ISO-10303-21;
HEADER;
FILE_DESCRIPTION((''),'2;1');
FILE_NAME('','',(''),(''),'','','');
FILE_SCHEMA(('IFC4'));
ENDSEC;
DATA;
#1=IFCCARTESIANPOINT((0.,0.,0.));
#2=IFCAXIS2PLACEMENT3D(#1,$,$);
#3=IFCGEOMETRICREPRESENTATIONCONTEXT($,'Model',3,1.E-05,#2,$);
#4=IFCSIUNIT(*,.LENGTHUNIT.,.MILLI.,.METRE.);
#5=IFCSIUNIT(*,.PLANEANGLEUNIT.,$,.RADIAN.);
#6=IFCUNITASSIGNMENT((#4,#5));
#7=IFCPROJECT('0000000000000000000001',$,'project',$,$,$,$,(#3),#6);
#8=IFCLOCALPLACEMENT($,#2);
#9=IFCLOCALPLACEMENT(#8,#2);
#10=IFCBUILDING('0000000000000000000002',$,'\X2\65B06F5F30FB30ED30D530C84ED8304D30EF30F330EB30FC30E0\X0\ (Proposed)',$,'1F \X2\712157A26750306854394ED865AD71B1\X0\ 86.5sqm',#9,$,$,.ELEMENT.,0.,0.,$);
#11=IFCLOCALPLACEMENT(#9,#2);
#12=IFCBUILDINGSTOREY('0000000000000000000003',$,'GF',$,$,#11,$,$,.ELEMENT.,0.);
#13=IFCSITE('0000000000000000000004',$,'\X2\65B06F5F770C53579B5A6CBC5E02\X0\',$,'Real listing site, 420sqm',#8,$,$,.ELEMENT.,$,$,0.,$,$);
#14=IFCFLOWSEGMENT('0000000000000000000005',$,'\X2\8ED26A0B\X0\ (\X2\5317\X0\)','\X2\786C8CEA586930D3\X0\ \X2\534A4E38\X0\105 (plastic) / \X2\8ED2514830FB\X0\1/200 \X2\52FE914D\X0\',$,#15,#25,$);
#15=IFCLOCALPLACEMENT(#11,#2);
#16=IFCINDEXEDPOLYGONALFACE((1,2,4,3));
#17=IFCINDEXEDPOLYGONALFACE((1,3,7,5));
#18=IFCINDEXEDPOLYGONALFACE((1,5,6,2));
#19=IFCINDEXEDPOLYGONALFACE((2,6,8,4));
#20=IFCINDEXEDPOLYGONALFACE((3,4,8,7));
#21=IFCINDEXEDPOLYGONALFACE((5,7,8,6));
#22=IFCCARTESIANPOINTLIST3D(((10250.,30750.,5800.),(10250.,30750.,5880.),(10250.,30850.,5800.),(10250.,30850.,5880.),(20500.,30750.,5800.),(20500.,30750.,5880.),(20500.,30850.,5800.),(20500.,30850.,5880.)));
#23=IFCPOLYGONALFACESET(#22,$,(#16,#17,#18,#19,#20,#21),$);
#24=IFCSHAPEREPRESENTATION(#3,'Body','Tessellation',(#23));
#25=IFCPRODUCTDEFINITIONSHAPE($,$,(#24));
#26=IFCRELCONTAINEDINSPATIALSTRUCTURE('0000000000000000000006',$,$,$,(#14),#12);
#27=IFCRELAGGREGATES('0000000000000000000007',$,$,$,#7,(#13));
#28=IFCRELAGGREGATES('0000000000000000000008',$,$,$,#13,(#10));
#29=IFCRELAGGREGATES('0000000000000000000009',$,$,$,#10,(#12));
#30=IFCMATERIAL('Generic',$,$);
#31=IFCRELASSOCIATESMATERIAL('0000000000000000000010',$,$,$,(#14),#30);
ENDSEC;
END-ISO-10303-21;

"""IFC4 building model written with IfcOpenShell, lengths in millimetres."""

from ifc_helpers import new_model, si_unit, frame, frame_2d, origin, place, context, project, spatial, rectangle, extrude, material, element, save


model = new_model("IFC4")

# Units and contexts
model_context = context("Model", 3, precision=1e-05, world=origin())
ifc_project = project(units=[si_unit("LENGTHUNIT", "METRE", prefix="MILLI"), si_unit("PLANEANGLEUNIT", "RADIAN")], contexts=[model_context])

# Site, building, storey
site_placement = place(None, origin())
site = spatial("IfcSite", under=ifc_project, at=site_placement, Name="新潟県南魚沼市", ObjectType="Real listing site, 420sqm", CompositionType="ELEMENT", RefElevation=0.0)
building_placement = place(site_placement, origin())
building = spatial("IfcBuilding", under=site, at=building_placement, Name="新潟・ロフト付きワンルーム (Proposed)", ObjectType="1F 無垢材と吹付断熱 86.5sqm", CompositionType="ELEMENT", ElevationOfRefHeight=0.0, ElevationOfTerrain=0.0)
storey_placement = place(building_placement, origin())
storey = spatial("IfcBuildingStorey", under=building, at=storey_placement, Name="GF", CompositionType="ELEMENT", Elevation=0.0)

# Shared definitions
ifc_material_1 = material(Name="Generic")

# Flow segment
flow_segment_1_placement = place(storey_placement, frame((5125.0, 15375.0, 2900.0)))
element("IfcFlowSegment", 1, at=flow_segment_1_placement, inside=storey, material=ifc_material_1, Name="軒樋 (北)", Description="硬質塩ビ 半丸105 (plastic) / 軒先・1/200 勾配", context=model_context, shape_type="SweptSolid", body=[
    extrude(rectangle(XDim=10250.0, YDim=100.0, at=frame_2d((5125.0, 50.0))), frame((5125.0, 15375.0, 2900.0)), (0.0, 0.0, 1.0), 80.0),
])

save(model, "model.ifc")
